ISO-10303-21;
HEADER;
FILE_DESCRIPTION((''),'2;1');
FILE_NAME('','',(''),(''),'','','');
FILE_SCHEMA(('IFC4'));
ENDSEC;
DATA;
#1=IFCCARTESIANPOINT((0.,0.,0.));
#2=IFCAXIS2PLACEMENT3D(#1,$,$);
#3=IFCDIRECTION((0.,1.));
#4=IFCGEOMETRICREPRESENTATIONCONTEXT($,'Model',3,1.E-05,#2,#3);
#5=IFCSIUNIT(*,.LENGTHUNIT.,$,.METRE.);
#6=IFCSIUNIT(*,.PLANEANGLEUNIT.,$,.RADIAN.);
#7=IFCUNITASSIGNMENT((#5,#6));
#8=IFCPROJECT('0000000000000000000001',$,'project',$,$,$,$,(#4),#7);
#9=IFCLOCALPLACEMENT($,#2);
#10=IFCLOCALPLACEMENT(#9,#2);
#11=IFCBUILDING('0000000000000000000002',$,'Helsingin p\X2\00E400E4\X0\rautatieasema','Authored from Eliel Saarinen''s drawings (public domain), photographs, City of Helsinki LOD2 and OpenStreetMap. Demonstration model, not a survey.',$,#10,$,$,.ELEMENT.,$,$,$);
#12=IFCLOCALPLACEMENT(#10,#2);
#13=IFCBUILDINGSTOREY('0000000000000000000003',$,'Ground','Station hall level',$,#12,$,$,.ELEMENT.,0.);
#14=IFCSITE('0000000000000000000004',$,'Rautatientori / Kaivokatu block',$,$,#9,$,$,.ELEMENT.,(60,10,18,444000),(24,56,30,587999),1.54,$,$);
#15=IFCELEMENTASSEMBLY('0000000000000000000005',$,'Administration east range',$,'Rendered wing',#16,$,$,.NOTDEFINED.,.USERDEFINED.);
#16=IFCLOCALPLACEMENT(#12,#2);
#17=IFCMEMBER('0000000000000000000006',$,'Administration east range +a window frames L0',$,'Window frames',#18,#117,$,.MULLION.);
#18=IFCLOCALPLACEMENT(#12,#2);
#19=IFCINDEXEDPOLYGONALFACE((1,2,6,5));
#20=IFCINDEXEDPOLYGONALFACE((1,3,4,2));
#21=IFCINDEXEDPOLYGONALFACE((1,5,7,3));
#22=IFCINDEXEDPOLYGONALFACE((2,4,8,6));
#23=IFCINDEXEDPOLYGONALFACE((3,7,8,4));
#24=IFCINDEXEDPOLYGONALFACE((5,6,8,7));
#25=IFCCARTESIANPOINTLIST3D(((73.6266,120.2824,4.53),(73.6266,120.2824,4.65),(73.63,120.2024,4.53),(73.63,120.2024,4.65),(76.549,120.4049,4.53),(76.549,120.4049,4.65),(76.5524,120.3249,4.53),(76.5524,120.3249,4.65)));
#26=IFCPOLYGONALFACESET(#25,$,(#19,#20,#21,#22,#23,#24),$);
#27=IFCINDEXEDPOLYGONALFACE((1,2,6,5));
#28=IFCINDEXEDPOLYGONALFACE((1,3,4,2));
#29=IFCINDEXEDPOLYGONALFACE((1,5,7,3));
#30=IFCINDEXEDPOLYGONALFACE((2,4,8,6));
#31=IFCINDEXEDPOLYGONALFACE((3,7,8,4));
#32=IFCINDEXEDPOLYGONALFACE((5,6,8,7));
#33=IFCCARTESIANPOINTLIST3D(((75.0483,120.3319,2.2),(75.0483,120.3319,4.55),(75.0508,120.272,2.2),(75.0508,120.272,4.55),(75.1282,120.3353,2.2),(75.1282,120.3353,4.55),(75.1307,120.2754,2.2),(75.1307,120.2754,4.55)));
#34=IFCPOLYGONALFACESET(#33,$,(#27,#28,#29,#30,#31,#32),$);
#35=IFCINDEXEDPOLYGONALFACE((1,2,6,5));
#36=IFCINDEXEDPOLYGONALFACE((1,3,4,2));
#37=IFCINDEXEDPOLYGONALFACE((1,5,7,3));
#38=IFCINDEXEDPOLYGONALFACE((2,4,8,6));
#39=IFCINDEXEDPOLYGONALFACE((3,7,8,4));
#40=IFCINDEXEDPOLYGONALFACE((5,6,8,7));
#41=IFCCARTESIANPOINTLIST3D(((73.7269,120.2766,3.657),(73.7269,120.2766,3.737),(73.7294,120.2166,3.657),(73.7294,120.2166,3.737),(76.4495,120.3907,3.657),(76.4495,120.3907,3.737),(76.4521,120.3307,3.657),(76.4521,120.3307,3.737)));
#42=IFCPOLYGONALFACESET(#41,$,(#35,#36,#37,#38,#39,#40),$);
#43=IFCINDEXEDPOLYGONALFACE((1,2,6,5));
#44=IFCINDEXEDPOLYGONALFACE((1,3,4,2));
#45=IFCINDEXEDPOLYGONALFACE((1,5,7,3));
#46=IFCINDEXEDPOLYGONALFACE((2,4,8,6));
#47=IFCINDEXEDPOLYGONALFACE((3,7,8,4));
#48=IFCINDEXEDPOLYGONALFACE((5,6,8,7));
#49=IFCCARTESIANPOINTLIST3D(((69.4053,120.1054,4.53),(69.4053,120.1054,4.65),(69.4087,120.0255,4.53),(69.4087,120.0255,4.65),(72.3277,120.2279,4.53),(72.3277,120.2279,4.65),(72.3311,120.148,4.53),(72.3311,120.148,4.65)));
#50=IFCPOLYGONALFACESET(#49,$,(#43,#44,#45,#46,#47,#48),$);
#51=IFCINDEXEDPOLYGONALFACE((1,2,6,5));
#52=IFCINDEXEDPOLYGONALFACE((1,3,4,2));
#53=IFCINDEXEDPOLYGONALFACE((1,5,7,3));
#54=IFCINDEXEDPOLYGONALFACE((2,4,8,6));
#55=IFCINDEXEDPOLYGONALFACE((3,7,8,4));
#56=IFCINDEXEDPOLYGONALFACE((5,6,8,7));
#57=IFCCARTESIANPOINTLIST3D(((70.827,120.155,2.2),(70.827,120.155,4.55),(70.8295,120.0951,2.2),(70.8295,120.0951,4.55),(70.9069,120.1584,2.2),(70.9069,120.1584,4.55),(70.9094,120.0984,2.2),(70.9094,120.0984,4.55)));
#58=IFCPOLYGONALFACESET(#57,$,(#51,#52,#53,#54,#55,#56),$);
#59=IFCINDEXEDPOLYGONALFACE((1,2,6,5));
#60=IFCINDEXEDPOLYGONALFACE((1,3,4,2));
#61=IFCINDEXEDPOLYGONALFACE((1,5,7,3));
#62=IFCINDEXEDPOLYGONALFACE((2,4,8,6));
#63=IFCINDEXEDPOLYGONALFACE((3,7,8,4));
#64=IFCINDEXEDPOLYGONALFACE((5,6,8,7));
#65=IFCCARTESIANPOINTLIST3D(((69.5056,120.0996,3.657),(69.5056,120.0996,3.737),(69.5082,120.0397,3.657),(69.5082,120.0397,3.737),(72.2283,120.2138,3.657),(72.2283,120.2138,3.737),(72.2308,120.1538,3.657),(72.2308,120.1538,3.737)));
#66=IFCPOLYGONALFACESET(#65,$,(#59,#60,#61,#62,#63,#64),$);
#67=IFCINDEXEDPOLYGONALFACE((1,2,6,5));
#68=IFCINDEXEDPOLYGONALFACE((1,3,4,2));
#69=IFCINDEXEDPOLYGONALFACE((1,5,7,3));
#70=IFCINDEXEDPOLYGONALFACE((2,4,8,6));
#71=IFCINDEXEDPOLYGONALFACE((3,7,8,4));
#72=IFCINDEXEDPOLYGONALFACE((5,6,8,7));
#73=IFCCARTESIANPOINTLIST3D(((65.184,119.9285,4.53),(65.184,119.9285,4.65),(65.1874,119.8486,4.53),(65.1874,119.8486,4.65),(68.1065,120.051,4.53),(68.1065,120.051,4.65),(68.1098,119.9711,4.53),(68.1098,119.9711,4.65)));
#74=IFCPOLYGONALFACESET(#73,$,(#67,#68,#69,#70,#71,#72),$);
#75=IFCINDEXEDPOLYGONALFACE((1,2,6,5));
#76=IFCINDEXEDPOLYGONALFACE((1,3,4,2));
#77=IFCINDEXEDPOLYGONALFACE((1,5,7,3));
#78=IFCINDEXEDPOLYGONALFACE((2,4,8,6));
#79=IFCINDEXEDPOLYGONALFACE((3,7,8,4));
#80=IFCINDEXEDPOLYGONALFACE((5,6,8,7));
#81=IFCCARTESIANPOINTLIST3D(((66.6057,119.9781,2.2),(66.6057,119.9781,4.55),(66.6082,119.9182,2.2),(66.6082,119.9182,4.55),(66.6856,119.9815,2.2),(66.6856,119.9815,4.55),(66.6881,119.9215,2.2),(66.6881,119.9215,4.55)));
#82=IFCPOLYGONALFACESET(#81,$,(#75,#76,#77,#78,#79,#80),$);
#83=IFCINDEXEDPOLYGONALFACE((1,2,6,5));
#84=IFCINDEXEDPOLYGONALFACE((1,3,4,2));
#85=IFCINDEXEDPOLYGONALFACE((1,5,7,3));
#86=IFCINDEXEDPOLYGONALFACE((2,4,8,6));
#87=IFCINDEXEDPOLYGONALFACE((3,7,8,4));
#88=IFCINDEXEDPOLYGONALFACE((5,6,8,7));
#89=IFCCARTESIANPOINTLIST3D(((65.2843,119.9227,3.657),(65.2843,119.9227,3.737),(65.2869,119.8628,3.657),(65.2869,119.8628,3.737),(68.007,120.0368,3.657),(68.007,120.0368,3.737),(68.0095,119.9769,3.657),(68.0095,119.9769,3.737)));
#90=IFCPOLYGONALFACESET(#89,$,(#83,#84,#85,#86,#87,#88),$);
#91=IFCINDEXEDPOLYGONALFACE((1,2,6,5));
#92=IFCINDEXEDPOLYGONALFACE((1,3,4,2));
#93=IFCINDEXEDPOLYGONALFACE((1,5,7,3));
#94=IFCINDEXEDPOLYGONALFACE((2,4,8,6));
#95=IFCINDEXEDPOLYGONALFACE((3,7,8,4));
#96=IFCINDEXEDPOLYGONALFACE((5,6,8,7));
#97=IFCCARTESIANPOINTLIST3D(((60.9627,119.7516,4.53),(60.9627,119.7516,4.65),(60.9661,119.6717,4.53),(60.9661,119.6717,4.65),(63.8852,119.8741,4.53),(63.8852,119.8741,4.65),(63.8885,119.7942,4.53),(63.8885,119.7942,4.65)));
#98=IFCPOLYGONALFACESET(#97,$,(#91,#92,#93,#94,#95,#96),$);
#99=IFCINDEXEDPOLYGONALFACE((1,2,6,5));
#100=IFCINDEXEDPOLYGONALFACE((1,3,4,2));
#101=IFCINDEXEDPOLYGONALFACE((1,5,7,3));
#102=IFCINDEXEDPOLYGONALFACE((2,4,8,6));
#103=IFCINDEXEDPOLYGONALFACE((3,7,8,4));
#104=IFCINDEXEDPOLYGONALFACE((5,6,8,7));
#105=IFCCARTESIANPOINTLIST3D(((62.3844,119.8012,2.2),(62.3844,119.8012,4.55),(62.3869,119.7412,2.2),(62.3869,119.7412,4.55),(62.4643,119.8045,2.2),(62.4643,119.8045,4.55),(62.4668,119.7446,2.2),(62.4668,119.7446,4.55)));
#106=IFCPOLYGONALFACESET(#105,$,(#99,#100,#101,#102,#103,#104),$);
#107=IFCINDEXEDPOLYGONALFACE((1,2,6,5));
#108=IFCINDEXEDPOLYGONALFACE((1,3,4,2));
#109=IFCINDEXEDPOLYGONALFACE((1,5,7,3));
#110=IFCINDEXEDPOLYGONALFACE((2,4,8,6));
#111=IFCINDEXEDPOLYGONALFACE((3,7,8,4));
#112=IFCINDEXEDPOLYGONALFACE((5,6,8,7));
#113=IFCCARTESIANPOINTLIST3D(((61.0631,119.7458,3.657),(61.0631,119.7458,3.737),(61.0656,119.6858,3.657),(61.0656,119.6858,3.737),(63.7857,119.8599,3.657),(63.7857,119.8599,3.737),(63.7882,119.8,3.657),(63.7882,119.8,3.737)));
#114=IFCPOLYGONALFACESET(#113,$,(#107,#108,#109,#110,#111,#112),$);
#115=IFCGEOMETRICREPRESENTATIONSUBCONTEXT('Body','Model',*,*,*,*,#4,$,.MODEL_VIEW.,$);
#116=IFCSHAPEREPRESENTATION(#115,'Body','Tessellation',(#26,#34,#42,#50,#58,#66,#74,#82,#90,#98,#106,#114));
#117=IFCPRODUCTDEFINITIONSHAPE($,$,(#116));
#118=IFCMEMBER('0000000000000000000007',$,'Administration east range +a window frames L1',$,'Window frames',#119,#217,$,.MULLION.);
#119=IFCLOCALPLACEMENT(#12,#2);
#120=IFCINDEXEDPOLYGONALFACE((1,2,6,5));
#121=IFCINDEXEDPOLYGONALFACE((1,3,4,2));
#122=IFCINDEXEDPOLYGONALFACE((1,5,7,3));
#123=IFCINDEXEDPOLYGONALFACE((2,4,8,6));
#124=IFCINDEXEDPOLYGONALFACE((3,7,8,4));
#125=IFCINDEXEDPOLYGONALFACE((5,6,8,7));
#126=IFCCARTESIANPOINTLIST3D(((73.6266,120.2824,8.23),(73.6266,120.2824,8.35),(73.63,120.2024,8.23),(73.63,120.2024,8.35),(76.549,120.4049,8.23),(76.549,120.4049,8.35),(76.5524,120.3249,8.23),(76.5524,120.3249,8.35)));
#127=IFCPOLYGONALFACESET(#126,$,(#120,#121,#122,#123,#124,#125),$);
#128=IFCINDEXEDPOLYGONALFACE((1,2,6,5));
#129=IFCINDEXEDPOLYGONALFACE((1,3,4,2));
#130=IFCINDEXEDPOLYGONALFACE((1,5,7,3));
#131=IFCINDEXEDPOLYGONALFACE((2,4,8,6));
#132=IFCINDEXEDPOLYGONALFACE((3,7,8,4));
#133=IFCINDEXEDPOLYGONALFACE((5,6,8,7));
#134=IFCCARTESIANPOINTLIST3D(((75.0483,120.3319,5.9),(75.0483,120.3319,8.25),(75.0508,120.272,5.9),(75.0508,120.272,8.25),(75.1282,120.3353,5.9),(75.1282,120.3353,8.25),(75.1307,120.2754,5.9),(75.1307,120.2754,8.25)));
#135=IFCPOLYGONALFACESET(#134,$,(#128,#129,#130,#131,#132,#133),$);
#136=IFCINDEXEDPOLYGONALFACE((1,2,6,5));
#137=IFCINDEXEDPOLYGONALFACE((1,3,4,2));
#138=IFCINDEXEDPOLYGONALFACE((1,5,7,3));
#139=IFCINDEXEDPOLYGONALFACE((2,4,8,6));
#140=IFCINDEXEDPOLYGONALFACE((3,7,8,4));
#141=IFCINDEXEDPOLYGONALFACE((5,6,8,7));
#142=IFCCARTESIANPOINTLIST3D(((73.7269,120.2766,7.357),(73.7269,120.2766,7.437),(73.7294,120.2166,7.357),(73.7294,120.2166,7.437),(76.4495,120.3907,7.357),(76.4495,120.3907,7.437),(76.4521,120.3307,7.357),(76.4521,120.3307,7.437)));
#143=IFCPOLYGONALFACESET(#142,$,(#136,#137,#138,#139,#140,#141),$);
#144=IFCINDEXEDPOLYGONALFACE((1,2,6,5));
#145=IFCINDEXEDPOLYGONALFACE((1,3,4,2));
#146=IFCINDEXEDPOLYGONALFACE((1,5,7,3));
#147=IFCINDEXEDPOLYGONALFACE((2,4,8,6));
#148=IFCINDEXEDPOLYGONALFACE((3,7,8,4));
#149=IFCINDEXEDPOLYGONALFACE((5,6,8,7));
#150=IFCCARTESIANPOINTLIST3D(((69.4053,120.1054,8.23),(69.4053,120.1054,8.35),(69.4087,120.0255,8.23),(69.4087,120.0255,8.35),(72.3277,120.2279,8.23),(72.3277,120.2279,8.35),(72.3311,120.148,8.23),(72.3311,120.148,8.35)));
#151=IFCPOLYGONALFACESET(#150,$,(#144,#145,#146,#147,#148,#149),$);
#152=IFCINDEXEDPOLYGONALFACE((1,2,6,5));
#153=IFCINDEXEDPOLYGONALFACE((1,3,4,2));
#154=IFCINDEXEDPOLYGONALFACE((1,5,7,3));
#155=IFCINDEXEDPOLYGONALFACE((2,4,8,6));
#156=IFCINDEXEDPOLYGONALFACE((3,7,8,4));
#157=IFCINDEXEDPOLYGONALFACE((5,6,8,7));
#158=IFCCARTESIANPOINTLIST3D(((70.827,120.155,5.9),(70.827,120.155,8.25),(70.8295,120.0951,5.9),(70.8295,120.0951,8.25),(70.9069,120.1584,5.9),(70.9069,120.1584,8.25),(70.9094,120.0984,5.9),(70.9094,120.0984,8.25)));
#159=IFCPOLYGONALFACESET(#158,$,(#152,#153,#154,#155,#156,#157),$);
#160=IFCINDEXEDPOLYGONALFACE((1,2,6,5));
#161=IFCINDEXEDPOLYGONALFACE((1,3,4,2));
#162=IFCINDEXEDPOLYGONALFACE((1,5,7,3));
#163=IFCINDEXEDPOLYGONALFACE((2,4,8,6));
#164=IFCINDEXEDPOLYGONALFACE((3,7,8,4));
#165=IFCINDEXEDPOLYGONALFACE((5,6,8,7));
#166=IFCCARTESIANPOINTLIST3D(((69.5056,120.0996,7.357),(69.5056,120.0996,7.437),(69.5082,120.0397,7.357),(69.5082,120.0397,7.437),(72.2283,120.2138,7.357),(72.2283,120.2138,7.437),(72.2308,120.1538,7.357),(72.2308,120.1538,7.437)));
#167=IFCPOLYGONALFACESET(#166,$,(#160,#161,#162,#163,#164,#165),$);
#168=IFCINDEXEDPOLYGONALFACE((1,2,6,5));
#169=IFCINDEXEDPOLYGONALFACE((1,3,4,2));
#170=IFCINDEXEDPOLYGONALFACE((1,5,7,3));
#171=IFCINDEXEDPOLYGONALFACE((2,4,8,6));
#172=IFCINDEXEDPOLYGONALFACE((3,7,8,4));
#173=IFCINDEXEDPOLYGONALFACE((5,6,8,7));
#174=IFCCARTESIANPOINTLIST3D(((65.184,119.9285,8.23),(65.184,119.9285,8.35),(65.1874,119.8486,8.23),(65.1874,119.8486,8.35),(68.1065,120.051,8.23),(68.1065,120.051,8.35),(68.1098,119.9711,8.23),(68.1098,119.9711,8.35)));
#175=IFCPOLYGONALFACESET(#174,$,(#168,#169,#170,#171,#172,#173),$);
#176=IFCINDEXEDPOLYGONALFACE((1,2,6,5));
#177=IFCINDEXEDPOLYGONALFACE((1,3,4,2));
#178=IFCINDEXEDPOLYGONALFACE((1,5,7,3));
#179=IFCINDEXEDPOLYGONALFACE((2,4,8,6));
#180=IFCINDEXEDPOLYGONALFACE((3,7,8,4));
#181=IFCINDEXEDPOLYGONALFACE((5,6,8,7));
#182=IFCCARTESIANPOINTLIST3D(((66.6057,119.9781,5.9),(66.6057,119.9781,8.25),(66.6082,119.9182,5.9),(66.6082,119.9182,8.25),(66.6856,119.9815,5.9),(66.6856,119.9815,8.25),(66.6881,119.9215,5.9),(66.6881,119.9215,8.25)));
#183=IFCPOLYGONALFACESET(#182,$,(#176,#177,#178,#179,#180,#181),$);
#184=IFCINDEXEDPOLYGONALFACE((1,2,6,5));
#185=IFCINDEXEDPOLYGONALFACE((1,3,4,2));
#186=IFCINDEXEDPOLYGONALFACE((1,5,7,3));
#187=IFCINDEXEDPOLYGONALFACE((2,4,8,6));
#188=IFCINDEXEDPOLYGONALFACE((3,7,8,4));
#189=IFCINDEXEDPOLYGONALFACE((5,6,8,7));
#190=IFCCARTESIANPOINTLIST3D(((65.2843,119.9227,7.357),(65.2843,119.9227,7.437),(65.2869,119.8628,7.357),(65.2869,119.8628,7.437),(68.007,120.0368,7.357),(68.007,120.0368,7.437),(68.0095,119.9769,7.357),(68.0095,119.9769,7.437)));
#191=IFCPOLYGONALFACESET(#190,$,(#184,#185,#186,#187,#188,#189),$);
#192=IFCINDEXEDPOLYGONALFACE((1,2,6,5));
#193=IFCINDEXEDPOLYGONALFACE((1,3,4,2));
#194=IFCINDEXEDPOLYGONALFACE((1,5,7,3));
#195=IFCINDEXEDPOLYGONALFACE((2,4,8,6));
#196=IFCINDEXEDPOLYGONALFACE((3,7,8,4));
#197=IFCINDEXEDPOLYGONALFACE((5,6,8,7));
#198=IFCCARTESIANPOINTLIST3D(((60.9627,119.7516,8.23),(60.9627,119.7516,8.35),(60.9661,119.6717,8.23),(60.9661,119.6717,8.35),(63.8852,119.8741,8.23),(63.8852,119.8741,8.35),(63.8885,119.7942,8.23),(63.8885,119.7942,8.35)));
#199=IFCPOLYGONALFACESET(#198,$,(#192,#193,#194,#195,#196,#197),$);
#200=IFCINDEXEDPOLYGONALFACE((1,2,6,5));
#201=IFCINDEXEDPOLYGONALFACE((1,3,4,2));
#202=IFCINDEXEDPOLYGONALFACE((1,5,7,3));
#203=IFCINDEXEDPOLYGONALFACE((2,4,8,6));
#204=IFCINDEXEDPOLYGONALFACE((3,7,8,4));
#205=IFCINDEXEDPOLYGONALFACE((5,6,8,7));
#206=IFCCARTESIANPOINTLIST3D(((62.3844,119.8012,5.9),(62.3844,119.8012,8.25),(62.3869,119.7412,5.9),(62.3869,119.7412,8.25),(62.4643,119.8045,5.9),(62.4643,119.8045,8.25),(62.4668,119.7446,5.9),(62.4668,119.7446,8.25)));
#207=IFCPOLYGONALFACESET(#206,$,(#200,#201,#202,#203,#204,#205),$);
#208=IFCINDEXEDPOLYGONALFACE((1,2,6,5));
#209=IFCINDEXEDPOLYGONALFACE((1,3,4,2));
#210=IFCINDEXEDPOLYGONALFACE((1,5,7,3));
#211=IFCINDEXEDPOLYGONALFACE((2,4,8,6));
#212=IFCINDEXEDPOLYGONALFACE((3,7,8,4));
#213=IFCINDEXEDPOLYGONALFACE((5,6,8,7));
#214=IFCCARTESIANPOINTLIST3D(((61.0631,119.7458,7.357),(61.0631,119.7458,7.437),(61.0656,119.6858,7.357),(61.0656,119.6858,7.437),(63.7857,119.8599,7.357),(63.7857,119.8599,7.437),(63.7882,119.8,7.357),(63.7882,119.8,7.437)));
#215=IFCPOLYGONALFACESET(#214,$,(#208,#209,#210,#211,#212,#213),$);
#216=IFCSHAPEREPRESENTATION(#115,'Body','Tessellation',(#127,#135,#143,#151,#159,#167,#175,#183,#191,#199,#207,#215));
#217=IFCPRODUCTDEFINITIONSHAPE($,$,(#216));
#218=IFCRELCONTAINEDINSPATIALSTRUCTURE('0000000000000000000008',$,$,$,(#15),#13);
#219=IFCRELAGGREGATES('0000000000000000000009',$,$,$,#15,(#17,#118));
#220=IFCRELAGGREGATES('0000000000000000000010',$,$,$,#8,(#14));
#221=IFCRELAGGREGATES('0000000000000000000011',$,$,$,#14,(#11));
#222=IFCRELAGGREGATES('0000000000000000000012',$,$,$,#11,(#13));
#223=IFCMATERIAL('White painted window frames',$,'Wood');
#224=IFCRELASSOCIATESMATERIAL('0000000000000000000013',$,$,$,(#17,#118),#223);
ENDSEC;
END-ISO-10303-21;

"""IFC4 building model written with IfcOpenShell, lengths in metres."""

from ifc_helpers import new_model, si_unit, direction, frame, frame_2d, origin, place, context, subcontext, project, spatial, rectangle, extrude, material, element, aggregate, save


model = new_model("IFC4")

# Units and contexts
model_context = context("Model", 3, precision=1e-05, world=origin(), true_north=direction((0.0, 1.0)))
body_context = subcontext(model_context, "Body", "Model", "MODEL_VIEW")
ifc_project = project(units=[si_unit("LENGTHUNIT", "METRE"), si_unit("PLANEANGLEUNIT", "RADIAN")], contexts=[model_context])

# Site, building, storey
site_placement = place(None, origin())
site = spatial("IfcSite", under=ifc_project, at=site_placement, Name="Rautatientori / Kaivokatu block", CompositionType="ELEMENT", RefLatitude=(60, 10, 18, 444000), RefLongitude=(24, 56, 30, 587999), RefElevation=1.54)
building_placement = place(site_placement, origin())
building = spatial("IfcBuilding", under=site, at=building_placement, Name="Helsingin päärautatieasema", Description="Authored from Eliel Saarinen's drawings (public domain), photographs, City of Helsinki LOD2 and OpenStreetMap. Demonstration model, not a survey.", CompositionType="ELEMENT")
storey_placement = place(building_placement, origin())
storey = spatial("IfcBuildingStorey", under=building, at=storey_placement, Name="Ground", Description="Station hall level", CompositionType="ELEMENT", Elevation=0.0)

# Shared definitions
ifc_material_1 = material(Name="White painted window frames", Category="Wood")

# Element assembly, members
assembly_1_placement = place(building_placement, origin())
assembly_1 = element("IfcElementAssembly", 1, at=assembly_1_placement, inside=storey, Name="Administration east range", ObjectType="Rendered wing", AssemblyPlace="NOTDEFINED", PredefinedType="USERDEFINED")
member_1_placement = place(building_placement, origin())
member_1 = element("IfcMember", 2, at=member_1_placement, material=ifc_material_1, Name="Administration east range +a window frames L0", ObjectType="Window frames", PredefinedType="MULLION", context=body_context, shape_type="SweptSolid", body=[
    extrude(rectangle(XDim=2.925, YDim=0.08, at=frame_2d((0.0, 0.0), x_axis=(-0.999123, -0.041876))), frame((75.0895, 120.3037, 4.53)), (0.0, 0.0, 1.0), 0.12),
    extrude(rectangle(XDim=0.08, YDim=0.06, at=frame_2d((0.0, 0.0), x_axis=(-0.999123, -0.041876))), frame((75.0895, 120.3037, 2.2)), (0.0, 0.0, 1.0), 2.35),
    extrude(rectangle(XDim=2.725, YDim=0.06, at=frame_2d((0.0, 0.0), x_axis=(-0.999123, -0.041876))), frame((75.0895, 120.3037, 3.657)), (0.0, 0.0, 1.0), 0.08),
    extrude(rectangle(XDim=2.925, YDim=0.08, at=frame_2d((0.0, 0.0), x_axis=(-0.999123, -0.041876))), frame((70.8682, 120.1267, 4.53)), (0.0, 0.0, 1.0), 0.12),
    extrude(rectangle(XDim=0.08, YDim=0.06, at=frame_2d((0.0, 0.0), x_axis=(-0.999123, -0.041876))), frame((70.8682, 120.1267, 2.2)), (0.0, 0.0, 1.0), 2.35),
    extrude(rectangle(XDim=2.725, YDim=0.06, at=frame_2d((0.0, 0.0), x_axis=(-0.999123, -0.041876))), frame((70.8682, 120.1267, 3.657)), (0.0, 0.0, 1.0), 0.08),
    extrude(rectangle(XDim=2.925, YDim=0.08, at=frame_2d((0.0, 0.0), x_axis=(-0.999123, -0.041876))), frame((66.6469, 119.9498, 4.53)), (0.0, 0.0, 1.0), 0.12),
    extrude(rectangle(XDim=0.08, YDim=0.06, at=frame_2d((0.0, 0.0), x_axis=(-0.999123, -0.041876))), frame((66.6469, 119.9498, 2.2)), (0.0, 0.0, 1.0), 2.35),
    extrude(rectangle(XDim=2.725, YDim=0.06, at=frame_2d((0.0, 0.0), x_axis=(-0.999123, -0.041876))), frame((66.6469, 119.9498, 3.657)), (0.0, 0.0, 1.0), 0.08),
    extrude(rectangle(XDim=2.925, YDim=0.08, at=frame_2d((0.0, 0.0), x_axis=(-0.999123, -0.041876))), frame((62.4256, 119.7729, 4.53)), (0.0, 0.0, 1.0), 0.12),
    extrude(rectangle(XDim=0.08, YDim=0.06, at=frame_2d((0.0, 0.0), x_axis=(-0.999123, -0.041876))), frame((62.4256, 119.7729, 2.2)), (0.0, 0.0, 1.0), 2.35),
    extrude(rectangle(XDim=2.725, YDim=0.06, at=frame_2d((0.0, 0.0), x_axis=(-0.999123, -0.041876))), frame((62.4256, 119.7729, 3.657)), (0.0, 0.0, 1.0), 0.08),
])
member_2_placement = place(building_placement, origin())
member_2 = element("IfcMember", 3, at=member_2_placement, material=ifc_material_1, Name="Administration east range +a window frames L1", ObjectType="Window frames", PredefinedType="MULLION", context=body_context, shape_type="SweptSolid", body=[
    extrude(rectangle(XDim=2.925, YDim=0.08, at=frame_2d((0.0, 0.0), x_axis=(-0.999123, -0.041876))), frame((75.0895, 120.3037, 8.23)), (0.0, 0.0, 1.0), 0.12),
    extrude(rectangle(XDim=0.08, YDim=0.06, at=frame_2d((0.0, 0.0), x_axis=(-0.999123, -0.041876))), frame((75.0895, 120.3037, 5.9)), (0.0, 0.0, 1.0), 2.35),
    extrude(rectangle(XDim=2.725, YDim=0.06, at=frame_2d((0.0, 0.0), x_axis=(-0.999123, -0.041876))), frame((75.0895, 120.3037, 7.357)), (0.0, 0.0, 1.0), 0.08),
    extrude(rectangle(XDim=2.925, YDim=0.08, at=frame_2d((0.0, 0.0), x_axis=(-0.999123, -0.041876))), frame((70.8682, 120.1267, 8.23)), (0.0, 0.0, 1.0), 0.12),
    extrude(rectangle(XDim=0.08, YDim=0.06, at=frame_2d((0.0, 0.0), x_axis=(-0.999123, -0.041876))), frame((70.8682, 120.1267, 5.9)), (0.0, 0.0, 1.0), 2.35),
    extrude(rectangle(XDim=2.725, YDim=0.06, at=frame_2d((0.0, 0.0), x_axis=(-0.999123, -0.041876))), frame((70.8682, 120.1267, 7.357)), (0.0, 0.0, 1.0), 0.08),
    extrude(rectangle(XDim=2.925, YDim=0.08, at=frame_2d((0.0, 0.0), x_axis=(-0.999123, -0.041876))), frame((66.6469, 119.9498, 8.23)), (0.0, 0.0, 1.0), 0.12),
    extrude(rectangle(XDim=0.08, YDim=0.06, at=frame_2d((0.0, 0.0), x_axis=(-0.999123, -0.041876))), frame((66.6469, 119.9498, 5.9)), (0.0, 0.0, 1.0), 2.35),
    extrude(rectangle(XDim=2.725, YDim=0.06, at=frame_2d((0.0, 0.0), x_axis=(-0.999123, -0.041876))), frame((66.6469, 119.9498, 7.357)), (0.0, 0.0, 1.0), 0.08),
    extrude(rectangle(XDim=2.925, YDim=0.08, at=frame_2d((0.0, 0.0), x_axis=(-0.999123, -0.041876))), frame((62.4256, 119.7729, 8.23)), (0.0, 0.0, 1.0), 0.12),
    extrude(rectangle(XDim=0.08, YDim=0.06, at=frame_2d((0.0, 0.0), x_axis=(-0.999123, -0.041876))), frame((62.4256, 119.7729, 5.9)), (0.0, 0.0, 1.0), 2.35),
    extrude(rectangle(XDim=2.725, YDim=0.06, at=frame_2d((0.0, 0.0), x_axis=(-0.999123, -0.041876))), frame((62.4256, 119.7729, 7.357)), (0.0, 0.0, 1.0), 0.08),
])

aggregate(assembly_1, [member_1, member_2])

save(model, "model.ifc")
